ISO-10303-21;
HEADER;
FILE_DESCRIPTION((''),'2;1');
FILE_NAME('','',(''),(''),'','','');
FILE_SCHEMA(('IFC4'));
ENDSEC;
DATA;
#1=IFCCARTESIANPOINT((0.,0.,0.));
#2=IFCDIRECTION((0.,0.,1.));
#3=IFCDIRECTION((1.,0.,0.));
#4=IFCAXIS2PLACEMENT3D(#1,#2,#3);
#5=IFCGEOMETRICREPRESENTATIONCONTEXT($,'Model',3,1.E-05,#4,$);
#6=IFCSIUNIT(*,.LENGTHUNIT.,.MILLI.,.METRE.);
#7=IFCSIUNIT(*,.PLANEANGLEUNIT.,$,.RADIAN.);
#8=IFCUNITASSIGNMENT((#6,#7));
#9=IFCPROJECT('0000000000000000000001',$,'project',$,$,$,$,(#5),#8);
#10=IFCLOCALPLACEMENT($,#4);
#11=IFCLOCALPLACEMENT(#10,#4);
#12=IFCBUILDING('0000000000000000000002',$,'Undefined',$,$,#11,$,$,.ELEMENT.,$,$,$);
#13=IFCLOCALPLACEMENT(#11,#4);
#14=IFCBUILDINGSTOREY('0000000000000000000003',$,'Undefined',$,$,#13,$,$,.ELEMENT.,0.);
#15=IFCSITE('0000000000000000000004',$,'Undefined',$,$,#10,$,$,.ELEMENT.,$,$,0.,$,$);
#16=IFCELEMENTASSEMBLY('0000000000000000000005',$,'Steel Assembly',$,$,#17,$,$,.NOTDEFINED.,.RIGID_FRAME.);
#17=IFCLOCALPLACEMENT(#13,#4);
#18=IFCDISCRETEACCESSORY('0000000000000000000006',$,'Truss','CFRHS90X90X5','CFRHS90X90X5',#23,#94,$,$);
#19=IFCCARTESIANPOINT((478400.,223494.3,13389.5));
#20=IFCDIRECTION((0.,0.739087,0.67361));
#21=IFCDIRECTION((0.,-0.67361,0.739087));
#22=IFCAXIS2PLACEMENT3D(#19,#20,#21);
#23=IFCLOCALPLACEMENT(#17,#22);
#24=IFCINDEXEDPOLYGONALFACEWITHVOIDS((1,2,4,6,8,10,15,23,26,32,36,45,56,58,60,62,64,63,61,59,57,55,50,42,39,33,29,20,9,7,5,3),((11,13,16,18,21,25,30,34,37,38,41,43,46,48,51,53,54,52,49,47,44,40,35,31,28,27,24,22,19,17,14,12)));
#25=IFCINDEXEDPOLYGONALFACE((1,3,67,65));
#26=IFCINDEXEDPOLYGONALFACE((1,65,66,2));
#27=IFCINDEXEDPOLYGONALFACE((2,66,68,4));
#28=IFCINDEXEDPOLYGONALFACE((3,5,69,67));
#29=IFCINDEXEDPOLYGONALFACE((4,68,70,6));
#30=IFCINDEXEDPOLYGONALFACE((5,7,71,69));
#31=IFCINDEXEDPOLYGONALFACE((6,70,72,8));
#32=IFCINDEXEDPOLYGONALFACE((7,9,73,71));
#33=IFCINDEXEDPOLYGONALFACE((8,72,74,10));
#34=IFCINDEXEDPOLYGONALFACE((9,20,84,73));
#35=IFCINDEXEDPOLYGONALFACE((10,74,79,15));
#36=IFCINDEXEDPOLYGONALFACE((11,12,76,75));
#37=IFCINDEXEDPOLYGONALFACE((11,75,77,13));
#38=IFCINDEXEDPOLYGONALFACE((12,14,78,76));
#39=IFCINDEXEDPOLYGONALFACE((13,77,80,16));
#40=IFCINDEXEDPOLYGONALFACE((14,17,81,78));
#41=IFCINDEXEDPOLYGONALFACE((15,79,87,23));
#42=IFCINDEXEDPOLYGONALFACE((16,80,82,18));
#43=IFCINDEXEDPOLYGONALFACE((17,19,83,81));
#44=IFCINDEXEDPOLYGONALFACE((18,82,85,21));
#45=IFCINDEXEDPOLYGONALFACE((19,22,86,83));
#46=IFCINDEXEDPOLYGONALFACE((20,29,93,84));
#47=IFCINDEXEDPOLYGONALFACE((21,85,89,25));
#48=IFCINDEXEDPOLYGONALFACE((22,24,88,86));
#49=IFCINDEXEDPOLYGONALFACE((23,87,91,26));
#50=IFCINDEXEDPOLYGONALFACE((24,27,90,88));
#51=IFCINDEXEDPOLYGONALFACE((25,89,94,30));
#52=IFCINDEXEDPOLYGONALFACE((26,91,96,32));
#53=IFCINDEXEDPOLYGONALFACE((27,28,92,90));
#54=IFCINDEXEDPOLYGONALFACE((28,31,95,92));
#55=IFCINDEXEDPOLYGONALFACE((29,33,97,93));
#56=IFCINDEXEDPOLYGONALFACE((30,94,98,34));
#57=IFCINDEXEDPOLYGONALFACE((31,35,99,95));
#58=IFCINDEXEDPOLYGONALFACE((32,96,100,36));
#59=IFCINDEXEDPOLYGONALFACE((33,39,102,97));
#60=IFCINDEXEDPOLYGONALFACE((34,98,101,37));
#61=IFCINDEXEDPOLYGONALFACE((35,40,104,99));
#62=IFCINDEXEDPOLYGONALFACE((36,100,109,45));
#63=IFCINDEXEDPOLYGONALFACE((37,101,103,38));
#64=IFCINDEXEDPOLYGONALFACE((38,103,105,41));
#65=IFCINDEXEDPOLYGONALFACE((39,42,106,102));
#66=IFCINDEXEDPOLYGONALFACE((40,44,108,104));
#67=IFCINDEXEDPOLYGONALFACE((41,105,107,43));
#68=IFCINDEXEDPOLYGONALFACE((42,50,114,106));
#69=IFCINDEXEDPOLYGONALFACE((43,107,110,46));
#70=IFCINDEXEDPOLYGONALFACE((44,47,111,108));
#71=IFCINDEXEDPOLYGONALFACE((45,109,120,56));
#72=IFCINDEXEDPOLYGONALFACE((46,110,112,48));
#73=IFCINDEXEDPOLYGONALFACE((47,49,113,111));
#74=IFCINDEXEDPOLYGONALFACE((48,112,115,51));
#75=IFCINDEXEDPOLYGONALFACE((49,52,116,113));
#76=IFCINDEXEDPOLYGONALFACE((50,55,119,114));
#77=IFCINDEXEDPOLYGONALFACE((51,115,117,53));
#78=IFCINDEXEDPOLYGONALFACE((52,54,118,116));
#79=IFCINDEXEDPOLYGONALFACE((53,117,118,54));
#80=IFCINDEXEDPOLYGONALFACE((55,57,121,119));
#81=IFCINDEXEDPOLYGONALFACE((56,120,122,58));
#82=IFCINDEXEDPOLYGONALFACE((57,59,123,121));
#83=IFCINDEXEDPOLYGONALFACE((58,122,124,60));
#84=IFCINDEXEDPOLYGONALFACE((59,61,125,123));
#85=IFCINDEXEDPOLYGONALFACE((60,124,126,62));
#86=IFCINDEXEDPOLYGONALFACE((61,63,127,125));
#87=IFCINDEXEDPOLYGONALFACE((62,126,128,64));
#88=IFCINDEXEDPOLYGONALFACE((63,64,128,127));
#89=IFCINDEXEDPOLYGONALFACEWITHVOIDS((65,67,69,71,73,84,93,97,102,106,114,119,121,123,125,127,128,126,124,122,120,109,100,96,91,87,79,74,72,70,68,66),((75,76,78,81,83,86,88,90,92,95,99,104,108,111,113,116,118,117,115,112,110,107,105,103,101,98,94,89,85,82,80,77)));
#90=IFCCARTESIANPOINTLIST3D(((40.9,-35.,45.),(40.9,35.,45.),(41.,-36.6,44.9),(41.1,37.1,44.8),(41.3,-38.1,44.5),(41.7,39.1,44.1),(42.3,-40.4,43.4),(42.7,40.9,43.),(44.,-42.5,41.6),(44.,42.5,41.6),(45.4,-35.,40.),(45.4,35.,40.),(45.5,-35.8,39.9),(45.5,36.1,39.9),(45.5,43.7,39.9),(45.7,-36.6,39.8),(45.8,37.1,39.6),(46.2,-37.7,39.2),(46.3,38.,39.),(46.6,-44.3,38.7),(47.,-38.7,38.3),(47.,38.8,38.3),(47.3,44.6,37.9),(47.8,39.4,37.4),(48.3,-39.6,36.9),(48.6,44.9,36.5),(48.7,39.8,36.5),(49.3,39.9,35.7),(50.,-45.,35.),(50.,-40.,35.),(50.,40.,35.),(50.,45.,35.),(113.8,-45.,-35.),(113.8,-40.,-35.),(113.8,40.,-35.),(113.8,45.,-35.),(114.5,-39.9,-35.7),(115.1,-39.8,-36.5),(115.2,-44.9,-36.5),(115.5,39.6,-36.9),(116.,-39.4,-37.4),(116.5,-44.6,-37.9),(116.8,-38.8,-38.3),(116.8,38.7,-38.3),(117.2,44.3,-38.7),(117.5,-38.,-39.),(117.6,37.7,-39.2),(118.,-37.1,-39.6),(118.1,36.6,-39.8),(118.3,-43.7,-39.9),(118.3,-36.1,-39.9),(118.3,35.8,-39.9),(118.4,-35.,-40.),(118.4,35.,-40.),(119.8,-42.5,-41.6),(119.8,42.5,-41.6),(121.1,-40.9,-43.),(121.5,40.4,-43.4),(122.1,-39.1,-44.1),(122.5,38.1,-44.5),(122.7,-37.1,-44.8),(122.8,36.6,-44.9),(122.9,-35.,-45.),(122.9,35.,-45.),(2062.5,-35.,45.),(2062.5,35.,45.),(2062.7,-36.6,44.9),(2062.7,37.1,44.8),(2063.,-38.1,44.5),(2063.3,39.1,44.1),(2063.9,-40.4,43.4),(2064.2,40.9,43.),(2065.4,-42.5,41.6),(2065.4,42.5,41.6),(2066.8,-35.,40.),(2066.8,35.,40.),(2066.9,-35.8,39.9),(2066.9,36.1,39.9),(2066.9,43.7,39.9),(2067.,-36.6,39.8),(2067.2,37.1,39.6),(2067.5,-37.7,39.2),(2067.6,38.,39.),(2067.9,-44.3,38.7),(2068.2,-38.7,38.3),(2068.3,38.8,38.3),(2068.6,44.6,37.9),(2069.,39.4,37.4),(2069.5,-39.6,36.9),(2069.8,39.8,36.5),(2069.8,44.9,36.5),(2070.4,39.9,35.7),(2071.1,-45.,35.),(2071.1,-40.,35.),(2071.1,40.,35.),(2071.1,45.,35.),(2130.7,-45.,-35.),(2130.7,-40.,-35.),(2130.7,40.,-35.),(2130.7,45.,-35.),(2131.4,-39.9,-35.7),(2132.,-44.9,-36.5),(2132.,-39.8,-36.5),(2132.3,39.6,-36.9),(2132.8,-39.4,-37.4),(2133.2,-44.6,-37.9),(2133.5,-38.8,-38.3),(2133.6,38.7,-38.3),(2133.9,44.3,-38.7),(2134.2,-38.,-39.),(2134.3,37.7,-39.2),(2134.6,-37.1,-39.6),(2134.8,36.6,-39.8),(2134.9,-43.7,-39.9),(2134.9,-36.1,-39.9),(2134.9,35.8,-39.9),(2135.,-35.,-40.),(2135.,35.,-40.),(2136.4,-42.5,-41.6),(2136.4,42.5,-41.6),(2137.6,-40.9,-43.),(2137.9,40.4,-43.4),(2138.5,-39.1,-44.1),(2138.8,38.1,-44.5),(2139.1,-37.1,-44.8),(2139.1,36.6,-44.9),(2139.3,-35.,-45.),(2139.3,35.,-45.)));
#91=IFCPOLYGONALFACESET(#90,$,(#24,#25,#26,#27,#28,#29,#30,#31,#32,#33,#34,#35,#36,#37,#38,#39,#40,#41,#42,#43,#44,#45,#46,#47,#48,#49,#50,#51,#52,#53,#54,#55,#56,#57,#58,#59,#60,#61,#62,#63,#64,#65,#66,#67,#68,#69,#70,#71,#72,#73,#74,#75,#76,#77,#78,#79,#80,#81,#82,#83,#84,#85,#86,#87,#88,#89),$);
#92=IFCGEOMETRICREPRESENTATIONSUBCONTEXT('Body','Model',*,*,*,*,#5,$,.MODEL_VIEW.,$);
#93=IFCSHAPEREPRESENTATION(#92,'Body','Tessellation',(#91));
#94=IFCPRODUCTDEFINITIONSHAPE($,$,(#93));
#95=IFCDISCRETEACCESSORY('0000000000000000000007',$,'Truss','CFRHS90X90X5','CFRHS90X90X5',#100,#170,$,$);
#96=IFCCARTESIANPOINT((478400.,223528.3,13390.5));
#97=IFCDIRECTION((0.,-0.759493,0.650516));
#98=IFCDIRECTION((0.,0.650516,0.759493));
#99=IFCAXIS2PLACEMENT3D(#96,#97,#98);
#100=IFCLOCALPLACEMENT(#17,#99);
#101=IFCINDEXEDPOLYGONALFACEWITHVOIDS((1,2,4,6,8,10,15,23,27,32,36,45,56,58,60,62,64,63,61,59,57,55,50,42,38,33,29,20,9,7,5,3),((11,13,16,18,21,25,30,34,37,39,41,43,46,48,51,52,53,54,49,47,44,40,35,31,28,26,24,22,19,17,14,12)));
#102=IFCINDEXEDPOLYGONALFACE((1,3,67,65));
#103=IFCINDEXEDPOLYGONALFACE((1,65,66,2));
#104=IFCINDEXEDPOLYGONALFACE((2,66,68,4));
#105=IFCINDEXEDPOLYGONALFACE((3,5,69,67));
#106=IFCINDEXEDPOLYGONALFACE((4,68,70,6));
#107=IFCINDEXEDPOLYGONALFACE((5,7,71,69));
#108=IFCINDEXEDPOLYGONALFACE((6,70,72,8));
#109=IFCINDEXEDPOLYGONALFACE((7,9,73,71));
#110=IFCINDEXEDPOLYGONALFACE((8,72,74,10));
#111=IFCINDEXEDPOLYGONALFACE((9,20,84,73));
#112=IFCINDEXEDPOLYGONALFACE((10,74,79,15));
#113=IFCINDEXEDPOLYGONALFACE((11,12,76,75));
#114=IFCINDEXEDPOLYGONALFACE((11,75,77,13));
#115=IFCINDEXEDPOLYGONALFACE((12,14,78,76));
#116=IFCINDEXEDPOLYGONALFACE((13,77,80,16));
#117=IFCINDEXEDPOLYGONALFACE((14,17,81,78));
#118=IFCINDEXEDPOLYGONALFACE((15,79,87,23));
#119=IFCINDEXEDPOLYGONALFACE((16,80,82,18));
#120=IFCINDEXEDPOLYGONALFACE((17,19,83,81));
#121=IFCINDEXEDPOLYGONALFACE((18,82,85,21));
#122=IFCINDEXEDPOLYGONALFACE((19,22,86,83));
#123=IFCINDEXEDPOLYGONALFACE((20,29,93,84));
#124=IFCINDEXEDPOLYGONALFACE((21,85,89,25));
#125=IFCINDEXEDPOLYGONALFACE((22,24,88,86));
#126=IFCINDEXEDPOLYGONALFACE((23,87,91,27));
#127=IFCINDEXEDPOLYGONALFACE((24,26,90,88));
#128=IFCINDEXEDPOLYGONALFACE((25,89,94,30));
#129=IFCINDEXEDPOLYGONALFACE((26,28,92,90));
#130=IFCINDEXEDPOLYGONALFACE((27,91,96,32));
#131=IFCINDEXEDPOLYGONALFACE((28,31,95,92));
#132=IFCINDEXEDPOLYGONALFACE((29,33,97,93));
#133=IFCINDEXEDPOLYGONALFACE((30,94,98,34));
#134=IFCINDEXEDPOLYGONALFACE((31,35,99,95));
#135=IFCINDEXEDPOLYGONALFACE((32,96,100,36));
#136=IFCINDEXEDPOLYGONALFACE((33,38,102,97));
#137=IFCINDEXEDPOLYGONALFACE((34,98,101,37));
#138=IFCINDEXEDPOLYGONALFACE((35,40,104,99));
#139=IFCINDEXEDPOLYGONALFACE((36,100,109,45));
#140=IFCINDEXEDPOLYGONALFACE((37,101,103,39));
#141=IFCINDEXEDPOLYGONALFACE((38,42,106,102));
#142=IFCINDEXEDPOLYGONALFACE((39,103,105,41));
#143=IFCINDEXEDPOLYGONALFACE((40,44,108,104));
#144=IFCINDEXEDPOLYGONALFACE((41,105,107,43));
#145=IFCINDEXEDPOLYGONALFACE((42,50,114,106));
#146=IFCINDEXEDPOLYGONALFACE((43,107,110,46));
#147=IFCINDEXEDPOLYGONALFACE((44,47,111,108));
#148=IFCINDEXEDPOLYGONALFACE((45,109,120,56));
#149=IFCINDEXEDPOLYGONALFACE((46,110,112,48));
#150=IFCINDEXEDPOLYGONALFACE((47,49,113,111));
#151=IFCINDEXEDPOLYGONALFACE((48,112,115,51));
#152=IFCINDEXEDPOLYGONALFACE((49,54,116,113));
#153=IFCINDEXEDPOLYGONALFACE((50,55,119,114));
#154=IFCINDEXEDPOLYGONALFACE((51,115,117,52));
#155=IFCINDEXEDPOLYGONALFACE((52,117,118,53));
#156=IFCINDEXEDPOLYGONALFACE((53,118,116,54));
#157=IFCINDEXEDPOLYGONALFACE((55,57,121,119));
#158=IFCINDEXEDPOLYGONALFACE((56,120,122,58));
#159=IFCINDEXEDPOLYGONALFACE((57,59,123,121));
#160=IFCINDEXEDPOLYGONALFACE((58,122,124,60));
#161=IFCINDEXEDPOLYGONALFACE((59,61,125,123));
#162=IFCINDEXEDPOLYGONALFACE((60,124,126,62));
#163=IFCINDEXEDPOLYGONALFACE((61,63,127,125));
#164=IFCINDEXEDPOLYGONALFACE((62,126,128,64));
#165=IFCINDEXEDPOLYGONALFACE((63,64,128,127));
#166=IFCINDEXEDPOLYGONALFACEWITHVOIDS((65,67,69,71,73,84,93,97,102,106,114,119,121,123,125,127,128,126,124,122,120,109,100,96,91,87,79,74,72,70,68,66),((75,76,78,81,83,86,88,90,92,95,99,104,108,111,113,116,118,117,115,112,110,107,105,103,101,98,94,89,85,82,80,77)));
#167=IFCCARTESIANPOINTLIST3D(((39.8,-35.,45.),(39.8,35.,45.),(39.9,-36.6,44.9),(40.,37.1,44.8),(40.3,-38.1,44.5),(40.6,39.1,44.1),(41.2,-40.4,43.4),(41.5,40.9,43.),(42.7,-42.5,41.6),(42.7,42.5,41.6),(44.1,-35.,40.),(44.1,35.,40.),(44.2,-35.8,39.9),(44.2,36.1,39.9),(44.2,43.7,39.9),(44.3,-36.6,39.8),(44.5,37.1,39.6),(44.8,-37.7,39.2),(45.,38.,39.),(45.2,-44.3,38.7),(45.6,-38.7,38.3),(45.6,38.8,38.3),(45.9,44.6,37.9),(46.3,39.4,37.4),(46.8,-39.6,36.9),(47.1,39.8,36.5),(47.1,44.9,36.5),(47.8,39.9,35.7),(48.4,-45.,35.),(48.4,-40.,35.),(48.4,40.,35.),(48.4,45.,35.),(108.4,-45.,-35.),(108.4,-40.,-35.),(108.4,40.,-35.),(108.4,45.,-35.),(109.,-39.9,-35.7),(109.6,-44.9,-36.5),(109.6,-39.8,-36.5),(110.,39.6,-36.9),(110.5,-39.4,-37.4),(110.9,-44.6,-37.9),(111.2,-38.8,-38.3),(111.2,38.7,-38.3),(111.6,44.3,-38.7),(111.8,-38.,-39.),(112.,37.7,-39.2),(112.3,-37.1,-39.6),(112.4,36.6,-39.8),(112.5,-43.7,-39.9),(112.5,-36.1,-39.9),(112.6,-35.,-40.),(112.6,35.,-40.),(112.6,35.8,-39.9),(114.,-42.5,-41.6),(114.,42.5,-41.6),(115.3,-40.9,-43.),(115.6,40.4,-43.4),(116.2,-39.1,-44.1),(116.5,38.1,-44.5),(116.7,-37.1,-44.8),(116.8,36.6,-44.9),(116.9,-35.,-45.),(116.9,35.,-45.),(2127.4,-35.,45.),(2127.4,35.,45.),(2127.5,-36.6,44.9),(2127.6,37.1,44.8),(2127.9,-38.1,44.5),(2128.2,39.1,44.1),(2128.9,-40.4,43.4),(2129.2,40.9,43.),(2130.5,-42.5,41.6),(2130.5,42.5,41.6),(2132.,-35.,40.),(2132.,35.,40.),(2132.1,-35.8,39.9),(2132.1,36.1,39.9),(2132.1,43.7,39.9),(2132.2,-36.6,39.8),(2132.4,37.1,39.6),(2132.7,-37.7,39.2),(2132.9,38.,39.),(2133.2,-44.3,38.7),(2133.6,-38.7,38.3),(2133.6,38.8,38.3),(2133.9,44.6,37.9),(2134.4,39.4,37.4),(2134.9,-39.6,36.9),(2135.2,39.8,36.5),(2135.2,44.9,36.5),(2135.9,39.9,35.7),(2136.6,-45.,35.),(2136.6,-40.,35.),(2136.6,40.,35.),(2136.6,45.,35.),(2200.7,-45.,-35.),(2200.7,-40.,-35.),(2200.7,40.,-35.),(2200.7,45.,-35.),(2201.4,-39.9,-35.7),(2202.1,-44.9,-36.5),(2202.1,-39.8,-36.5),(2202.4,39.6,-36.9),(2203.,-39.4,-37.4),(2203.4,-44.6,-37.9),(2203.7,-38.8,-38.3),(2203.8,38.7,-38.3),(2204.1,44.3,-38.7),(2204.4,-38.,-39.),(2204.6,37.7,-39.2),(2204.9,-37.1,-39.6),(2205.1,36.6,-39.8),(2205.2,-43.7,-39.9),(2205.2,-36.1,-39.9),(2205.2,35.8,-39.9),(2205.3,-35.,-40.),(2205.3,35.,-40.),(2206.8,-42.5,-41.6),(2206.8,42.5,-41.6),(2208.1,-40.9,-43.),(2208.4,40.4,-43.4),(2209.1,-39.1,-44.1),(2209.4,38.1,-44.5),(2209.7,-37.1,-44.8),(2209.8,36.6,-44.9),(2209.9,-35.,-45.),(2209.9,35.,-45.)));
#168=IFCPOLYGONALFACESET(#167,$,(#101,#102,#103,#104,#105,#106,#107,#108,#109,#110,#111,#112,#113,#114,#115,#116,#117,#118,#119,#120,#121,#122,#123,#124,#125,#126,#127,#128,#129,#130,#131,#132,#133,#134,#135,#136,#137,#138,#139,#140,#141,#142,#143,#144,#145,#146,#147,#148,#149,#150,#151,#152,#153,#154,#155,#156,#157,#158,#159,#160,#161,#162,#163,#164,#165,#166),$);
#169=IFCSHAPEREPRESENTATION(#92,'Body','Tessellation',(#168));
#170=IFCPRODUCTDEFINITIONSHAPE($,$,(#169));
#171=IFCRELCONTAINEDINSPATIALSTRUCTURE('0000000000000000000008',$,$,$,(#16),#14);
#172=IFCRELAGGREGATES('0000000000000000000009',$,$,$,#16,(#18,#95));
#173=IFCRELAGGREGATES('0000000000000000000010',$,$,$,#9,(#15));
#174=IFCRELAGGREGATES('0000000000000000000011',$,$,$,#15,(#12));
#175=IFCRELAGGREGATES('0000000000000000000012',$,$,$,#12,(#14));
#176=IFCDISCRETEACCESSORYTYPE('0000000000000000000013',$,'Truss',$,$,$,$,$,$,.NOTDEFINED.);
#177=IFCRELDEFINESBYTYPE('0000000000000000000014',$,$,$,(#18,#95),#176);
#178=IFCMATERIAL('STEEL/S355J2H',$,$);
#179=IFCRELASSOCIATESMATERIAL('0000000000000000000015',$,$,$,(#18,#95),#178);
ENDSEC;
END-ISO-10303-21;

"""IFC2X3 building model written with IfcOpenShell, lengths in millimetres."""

from ifc_helpers import new_model, si_unit, frame, origin_with_axes, origin_2d_with_axis, place, context, subcontext, project, spatial, hollow_rectangle, extrude, clip, halfspace, material, type_object, element, aggregate, save


model = new_model("IFC2X3")

# Units and contexts
model_context = context("Model", 3, precision=1e-05, world=origin_with_axes())
body_context = subcontext(model_context, "Body", "Model", "MODEL_VIEW")
ifc_project = project(units=[si_unit("LENGTHUNIT", "METRE", prefix="MILLI"), si_unit("PLANEANGLEUNIT", "RADIAN")], contexts=[model_context])

# Site, building, storey
site_placement = place(None, origin_with_axes())
site = spatial("IfcSite", under=ifc_project, at=site_placement, Name="Undefined", CompositionType="ELEMENT", RefElevation=0.0)
building_placement = place(site_placement, origin_with_axes())
building = spatial("IfcBuilding", under=site, at=building_placement, Name="Undefined", CompositionType="ELEMENT")
storey_placement = place(building_placement, origin_with_axes())
storey = spatial("IfcBuildingStorey", under=building, at=storey_placement, Name="Undefined", CompositionType="ELEMENT", Elevation=0.0)

# Element assembly, discrete accessories
assembly_1_placement = place(storey_placement, origin_with_axes())
assembly_1 = element("IfcElementAssembly", 1, at=assembly_1_placement, inside=storey, Name="Steel Assembly", AssemblyPlace="NOTDEFINED", PredefinedType="RIGID_FRAME")
ifc_material_1 = material(Name="STEEL/S355J2H")
discrete_accessory_type_1 = type_object("IfcDiscreteAccessoryType", Name="Truss")
discrete_accessory_1_placement = place(assembly_1_placement, frame((478400.0, 223494.3, 13389.5), z_axis=(0.0, 0.739087, 0.67361), x_axis=(0.0, -0.67361, 0.739087)))
discrete_accessory_1 = element("IfcDiscreteAccessory", 2, at=discrete_accessory_1_placement, type_object=discrete_accessory_type_1, material=ifc_material_1, Name="Truss", Description="CFRHS90X90X5", ObjectType="CFRHS90X90X5", context=body_context, shape_type="Clipping", body=[
    clip(clip(extrude(hollow_rectangle(XDim=90.0, YDim=90.0, WallThickness=5.0, InnerFilletRadius=5.0, OuterFilletRadius=10.0, at=origin_2d_with_axis()), frame((2184.0, 0.0, 0.0), z_axis=(-1.0, 0.0, 0.0), x_axis=(0.0, -1.0, 0.0)), (0.0, 0.0, 1.0), 2185.2), halfspace(frame((2062.5, 0.0, 45.0), z_axis=(-0.761088, 0.0, -0.648649), x_axis=(0.648649, 0.0, -0.761088)), True)), halfspace(frame((40.9, 0.0, 45.0), z_axis=(-0.739087, 0.0, -0.67361), x_axis=(0.67361, 0.0, -0.739087)), False)),
])
discrete_accessory_2_placement = place(assembly_1_placement, frame((478400.0, 223528.3, 13390.5), z_axis=(0.0, -0.759493, 0.650516), x_axis=(0.0, 0.650516, 0.759493)))
discrete_accessory_2 = element("IfcDiscreteAccessory", 3, at=discrete_accessory_2_placement, type_object=discrete_accessory_type_1, material=ifc_material_1, Name="Truss", Description="CFRHS90X90X5", ObjectType="CFRHS90X90X5", context=body_context, shape_type="Clipping", body=[
    clip(clip(extrude(hollow_rectangle(XDim=90.0, YDim=90.0, WallThickness=5.0, InnerFilletRadius=5.0, OuterFilletRadius=10.0, at=origin_2d_with_axis()), frame((2249.2, 0.0, 0.0), z_axis=(-1.0, 0.0, 0.0), x_axis=(0.0, -1.0, 0.0)), (0.0, 0.0, 1.0), 2251.4), halfspace(frame((2209.9, 0.0, -45.0), z_axis=(-0.737399, 0.0, -0.675457), x_axis=(-0.675457, 0.0, 0.737399)), True)), halfspace(frame((116.9, 0.0, -45.0), z_axis=(-0.759493, 0.0, -0.650516), x_axis=(-0.650516, 0.0, 0.759493)), False)),
])

aggregate(assembly_1, [discrete_accessory_1, discrete_accessory_2])

save(model, "model.ifc")
